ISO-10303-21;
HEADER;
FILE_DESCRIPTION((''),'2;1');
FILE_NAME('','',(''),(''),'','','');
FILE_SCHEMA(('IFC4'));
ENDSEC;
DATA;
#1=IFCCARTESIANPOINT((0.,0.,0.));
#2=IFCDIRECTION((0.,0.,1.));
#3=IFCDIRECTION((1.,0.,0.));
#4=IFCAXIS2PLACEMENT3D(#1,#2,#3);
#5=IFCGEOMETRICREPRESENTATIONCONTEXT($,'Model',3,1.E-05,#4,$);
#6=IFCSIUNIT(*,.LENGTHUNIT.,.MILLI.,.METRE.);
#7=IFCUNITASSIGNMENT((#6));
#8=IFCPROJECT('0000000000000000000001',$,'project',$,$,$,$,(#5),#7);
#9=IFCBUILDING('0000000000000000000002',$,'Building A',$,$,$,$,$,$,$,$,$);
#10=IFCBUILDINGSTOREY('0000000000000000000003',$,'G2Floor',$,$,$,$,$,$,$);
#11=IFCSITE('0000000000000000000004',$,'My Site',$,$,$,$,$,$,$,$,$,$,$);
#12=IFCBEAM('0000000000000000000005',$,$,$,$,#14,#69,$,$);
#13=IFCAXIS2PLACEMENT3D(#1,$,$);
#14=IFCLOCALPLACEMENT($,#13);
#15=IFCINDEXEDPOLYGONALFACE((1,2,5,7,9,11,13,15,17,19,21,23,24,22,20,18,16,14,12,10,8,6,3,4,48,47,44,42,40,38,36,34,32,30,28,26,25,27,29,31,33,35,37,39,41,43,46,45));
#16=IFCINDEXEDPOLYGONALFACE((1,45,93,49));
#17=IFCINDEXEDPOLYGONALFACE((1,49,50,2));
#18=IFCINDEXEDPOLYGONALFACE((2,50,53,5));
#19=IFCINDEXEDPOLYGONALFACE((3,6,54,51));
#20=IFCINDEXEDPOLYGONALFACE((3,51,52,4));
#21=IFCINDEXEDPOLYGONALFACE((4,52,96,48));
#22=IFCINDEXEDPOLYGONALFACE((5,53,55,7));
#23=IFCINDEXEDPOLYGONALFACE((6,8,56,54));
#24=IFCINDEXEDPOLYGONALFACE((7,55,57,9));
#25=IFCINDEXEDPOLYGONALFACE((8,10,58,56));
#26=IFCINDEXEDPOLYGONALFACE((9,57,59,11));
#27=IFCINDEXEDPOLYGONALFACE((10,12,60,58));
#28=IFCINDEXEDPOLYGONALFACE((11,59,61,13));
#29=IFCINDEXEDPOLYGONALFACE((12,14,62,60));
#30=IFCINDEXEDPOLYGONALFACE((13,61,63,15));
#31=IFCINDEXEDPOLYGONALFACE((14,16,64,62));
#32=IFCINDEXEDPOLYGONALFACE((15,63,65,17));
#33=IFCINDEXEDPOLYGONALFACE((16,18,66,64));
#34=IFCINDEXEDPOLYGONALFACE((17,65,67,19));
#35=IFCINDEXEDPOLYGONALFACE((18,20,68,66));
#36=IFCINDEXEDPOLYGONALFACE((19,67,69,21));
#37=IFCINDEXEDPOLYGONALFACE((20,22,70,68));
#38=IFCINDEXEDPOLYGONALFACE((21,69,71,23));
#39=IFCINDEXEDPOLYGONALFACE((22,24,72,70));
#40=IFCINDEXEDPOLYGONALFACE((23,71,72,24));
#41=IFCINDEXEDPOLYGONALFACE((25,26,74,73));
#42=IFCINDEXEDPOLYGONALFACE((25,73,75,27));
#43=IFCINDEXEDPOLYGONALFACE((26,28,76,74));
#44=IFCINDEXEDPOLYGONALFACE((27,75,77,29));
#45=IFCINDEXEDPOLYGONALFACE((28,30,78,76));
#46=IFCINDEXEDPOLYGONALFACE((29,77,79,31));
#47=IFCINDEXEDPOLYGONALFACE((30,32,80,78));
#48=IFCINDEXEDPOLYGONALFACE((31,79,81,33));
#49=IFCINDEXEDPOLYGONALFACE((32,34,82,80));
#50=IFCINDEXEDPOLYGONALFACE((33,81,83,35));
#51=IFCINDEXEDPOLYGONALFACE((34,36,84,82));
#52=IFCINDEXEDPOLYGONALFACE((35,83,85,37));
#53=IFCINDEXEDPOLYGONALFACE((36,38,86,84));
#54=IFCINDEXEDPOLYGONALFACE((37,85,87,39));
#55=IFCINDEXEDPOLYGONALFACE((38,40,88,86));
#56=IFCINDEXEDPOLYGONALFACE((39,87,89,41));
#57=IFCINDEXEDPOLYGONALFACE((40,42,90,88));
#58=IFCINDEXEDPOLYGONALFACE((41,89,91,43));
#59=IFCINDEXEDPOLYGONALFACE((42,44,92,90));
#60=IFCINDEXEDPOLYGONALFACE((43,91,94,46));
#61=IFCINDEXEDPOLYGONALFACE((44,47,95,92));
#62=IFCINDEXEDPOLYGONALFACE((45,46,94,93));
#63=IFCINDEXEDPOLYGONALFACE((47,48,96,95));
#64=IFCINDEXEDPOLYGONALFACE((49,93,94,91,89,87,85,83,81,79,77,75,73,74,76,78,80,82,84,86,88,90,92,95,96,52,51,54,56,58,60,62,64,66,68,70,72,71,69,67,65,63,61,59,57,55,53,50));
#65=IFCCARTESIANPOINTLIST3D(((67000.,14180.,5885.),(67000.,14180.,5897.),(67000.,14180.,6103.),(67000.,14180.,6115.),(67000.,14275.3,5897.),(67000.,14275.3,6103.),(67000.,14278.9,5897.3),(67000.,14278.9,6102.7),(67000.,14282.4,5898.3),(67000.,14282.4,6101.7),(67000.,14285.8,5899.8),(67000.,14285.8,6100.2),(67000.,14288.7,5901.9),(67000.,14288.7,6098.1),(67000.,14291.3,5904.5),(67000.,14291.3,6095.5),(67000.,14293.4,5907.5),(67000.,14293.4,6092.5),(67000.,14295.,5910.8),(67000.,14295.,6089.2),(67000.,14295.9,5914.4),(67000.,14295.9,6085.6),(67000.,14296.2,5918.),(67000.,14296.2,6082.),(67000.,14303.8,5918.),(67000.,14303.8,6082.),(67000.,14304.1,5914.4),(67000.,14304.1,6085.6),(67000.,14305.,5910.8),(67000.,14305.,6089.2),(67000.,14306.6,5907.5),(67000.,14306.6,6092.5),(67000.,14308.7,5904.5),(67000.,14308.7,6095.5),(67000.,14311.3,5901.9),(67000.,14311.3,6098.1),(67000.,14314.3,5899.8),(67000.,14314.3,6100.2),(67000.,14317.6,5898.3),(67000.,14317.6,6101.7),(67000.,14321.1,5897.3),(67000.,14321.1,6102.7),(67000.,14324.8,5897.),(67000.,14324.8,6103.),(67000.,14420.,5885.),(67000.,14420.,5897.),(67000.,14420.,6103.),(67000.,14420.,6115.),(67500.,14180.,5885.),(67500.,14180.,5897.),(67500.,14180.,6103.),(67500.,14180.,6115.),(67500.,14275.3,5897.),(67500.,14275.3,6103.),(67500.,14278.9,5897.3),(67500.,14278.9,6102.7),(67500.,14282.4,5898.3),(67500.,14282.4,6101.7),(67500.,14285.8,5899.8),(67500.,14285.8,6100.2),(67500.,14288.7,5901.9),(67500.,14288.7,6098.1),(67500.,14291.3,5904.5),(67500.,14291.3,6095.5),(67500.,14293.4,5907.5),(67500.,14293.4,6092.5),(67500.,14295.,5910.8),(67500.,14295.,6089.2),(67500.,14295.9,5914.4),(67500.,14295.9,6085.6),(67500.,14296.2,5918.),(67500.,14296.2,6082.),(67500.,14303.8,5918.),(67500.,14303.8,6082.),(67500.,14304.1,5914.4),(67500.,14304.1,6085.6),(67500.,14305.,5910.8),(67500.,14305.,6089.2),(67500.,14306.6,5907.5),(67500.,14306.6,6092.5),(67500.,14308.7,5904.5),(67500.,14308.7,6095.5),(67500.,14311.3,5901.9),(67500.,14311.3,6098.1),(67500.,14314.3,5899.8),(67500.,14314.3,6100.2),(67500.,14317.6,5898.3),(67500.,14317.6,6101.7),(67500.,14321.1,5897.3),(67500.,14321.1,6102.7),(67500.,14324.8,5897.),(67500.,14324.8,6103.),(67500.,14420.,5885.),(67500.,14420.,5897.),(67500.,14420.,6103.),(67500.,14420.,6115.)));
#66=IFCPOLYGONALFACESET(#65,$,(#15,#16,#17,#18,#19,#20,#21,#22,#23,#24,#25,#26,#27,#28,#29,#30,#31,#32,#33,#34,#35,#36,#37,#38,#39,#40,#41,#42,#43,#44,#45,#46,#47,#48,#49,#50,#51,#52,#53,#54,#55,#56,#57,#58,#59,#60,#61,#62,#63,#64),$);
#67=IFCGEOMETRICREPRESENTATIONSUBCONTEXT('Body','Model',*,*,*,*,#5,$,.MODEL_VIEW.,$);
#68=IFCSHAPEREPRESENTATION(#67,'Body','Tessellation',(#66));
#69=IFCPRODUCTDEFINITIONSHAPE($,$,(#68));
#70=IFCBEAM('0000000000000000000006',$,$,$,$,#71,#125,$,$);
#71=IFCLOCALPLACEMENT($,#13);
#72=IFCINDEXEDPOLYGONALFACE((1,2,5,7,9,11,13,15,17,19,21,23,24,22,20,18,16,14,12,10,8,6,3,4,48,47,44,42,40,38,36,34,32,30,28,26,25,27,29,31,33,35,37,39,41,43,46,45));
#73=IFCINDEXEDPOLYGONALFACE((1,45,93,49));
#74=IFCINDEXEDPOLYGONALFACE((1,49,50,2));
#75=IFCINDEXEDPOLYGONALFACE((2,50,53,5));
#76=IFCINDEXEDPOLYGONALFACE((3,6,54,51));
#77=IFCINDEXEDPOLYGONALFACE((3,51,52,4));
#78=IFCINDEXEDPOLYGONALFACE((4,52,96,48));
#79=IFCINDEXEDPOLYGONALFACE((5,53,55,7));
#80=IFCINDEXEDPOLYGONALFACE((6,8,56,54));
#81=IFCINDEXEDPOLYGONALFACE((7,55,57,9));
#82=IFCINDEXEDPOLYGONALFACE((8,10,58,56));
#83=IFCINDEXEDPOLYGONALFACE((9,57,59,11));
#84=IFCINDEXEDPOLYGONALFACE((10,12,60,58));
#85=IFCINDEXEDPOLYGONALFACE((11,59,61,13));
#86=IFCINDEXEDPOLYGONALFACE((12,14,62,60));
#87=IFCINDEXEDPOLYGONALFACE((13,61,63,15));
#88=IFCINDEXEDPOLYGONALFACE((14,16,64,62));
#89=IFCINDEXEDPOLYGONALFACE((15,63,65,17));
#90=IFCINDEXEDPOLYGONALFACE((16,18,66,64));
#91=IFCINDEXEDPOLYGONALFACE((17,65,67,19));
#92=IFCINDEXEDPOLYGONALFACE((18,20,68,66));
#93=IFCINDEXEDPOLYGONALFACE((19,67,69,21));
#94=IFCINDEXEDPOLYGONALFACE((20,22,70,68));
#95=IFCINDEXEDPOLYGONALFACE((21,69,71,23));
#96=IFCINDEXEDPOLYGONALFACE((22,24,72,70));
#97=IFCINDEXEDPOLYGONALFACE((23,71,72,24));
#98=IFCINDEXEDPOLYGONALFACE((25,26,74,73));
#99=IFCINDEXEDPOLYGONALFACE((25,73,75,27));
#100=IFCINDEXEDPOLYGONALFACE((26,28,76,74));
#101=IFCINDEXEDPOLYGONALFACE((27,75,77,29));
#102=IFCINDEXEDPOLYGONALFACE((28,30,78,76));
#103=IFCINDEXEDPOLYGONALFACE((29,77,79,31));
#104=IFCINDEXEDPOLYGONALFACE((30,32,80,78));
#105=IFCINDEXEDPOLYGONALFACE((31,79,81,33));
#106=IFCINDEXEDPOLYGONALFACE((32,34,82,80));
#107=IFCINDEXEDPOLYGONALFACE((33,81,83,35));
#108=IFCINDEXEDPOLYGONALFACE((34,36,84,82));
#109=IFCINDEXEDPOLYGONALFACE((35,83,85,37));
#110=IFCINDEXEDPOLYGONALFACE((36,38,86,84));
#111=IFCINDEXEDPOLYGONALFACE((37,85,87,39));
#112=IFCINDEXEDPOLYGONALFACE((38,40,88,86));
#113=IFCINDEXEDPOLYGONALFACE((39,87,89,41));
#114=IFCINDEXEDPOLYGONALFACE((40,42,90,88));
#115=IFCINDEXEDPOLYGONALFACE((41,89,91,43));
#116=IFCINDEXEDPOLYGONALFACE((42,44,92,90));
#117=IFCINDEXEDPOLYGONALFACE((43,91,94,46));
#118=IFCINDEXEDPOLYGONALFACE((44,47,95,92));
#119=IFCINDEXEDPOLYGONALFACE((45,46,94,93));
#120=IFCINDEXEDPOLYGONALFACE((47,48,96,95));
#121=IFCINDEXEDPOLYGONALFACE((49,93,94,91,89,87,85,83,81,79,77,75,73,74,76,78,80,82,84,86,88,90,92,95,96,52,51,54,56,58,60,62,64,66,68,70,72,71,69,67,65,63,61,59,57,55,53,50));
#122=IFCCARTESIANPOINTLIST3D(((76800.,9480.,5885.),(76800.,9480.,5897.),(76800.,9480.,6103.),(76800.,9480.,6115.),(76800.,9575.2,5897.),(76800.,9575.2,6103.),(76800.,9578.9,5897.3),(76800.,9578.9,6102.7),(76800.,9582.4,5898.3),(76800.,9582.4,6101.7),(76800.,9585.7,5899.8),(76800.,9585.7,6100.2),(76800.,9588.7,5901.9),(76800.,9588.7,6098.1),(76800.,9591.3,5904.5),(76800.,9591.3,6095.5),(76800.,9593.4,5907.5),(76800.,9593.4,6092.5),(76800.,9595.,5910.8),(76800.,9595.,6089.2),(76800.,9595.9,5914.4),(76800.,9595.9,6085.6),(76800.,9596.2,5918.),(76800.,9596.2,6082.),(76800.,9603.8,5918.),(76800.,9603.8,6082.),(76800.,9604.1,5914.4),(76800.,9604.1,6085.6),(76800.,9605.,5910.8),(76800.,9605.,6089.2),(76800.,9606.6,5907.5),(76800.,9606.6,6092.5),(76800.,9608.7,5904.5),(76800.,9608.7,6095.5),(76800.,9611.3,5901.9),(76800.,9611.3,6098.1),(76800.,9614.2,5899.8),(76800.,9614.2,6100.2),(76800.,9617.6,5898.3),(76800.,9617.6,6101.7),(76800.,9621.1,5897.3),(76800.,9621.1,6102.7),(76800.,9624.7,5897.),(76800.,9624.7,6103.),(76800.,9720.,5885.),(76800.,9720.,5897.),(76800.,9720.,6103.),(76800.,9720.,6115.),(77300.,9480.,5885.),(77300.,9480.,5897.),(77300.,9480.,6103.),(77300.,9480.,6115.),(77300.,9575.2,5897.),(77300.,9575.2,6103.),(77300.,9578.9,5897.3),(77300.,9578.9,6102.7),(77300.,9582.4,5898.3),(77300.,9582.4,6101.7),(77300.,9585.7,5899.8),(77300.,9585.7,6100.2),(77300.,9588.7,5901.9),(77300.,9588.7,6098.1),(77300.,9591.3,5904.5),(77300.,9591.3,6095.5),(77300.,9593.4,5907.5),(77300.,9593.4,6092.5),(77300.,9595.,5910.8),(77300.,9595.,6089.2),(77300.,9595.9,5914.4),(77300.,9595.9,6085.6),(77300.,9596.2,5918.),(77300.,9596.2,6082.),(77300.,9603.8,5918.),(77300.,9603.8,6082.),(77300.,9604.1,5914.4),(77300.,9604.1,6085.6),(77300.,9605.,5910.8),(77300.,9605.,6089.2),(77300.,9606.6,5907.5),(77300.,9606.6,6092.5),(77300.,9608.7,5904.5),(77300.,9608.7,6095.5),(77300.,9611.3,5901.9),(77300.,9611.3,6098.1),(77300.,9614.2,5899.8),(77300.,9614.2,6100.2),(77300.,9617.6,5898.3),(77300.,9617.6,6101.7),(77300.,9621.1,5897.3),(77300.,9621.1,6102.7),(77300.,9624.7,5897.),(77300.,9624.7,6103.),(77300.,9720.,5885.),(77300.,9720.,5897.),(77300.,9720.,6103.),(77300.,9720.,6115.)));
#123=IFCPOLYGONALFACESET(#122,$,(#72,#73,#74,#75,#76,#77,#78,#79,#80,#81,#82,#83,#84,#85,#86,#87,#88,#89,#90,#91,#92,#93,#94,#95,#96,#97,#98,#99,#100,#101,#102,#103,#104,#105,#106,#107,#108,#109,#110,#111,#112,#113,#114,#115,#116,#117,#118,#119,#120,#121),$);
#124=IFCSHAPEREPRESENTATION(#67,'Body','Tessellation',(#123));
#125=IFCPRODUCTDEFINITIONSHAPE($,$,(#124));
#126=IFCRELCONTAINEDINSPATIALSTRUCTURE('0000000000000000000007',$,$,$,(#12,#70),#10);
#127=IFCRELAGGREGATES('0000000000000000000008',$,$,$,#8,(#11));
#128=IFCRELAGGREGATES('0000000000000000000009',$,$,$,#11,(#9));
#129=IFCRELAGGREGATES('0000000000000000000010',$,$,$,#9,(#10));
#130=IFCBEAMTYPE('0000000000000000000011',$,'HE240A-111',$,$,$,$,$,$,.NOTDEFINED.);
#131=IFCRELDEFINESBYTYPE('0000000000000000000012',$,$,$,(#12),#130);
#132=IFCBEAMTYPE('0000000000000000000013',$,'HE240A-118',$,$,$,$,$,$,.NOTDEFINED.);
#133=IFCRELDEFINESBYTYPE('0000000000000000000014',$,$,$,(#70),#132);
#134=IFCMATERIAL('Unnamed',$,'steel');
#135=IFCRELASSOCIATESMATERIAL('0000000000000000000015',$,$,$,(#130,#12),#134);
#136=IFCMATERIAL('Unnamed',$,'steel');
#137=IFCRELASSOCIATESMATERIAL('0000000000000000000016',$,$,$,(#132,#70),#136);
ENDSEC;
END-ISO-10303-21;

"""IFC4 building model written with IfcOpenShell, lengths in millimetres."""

from ifc_helpers import new_model, si_unit, frame, origin_with_axes, place, context, subcontext, project, spatial, polyline, outline, extrude, material, material_profile, profile_set, profile_usage, type_object, element, save


model = new_model("IFC4")

# Units and contexts
model_context = context("Model", 3, precision=1e-05, world=origin_with_axes())
body_context = subcontext(model_context, "Body", "Model", "MODEL_VIEW")
ifc_project = project(units=[si_unit("LENGTHUNIT", "METRE", prefix="MILLI")], contexts=[model_context])

# Site, building, storey
site = spatial("IfcSite", under=ifc_project, Name="My Site")
building = spatial("IfcBuilding", under=site, Name="Building A")
storey = spatial("IfcBuildingStorey", under=building, Name="G2Floor")

# Beams
ifc_material_1 = material(Name="Unnamed", Category="steel")
ifc_material_profile_1 = material_profile(ifc_material_1, outline(polyline([(120.0, -115.0), (120.0, -103.0), (120.0, -103.0), (24.8, -103.0), (24.8, -103.0), (21.1, -102.7), (21.1, -102.7), (17.6, -101.7), (17.6, -101.7), (14.2, -100.2), (14.2, -100.2), (11.3, -98.1), (11.3, -98.1), (8.7, -95.5), (8.7, -95.5), (6.6, -92.5), (6.6, -92.5), (5.0, -89.2), (5.0, -89.2), (4.1, -85.6), (4.1, -85.6), (3.8, -82.0), (3.8, -82.0), (3.8, 82.0), (3.8, 82.0), (4.1, 85.6), (4.1, 85.6), (5.0, 89.2), (5.0, 89.2), (6.6, 92.5), (6.6, 92.5), (8.7, 95.5), (8.7, 95.5), (11.3, 98.1), (11.3, 98.1), (14.2, 100.2), (14.2, 100.2), (17.6, 101.7), (17.6, 101.7), (21.1, 102.7), (21.1, 102.7), (24.8, 103.0), (24.8, 103.0), (120.0, 103.0), (120.0, 103.0), (120.0, 115.0), (120.0, 115.0), (-120.0, 115.0), (-120.0, 115.0), (-120.0, 103.0), (-120.0, 103.0), (-24.8, 103.0), (-24.8, 103.0), (-21.1, 102.7), (-21.1, 102.7), (-17.6, 101.7), (-17.6, 101.7), (-14.2, 100.2), (-14.2, 100.2), (-11.3, 98.1), (-11.3, 98.1), (-8.7, 95.5), (-8.7, 95.5), (-6.6, 92.5), (-6.6, 92.5), (-5.0, 89.2), (-5.0, 89.2), (-4.1, 85.6), (-4.1, 85.6), (-3.8, 82.0), (-3.8, 82.0), (-3.8, -82.0), (-3.8, -82.0), (-4.1, -85.6), (-4.1, -85.6), (-5.0, -89.2), (-5.0, -89.2), (-6.6, -92.5), (-6.6, -92.5), (-8.7, -95.5), (-8.7, -95.5), (-11.3, -98.1), (-11.3, -98.1), (-14.2, -100.2), (-14.2, -100.2), (-17.6, -101.7), (-17.6, -101.7), (-21.1, -102.7), (-21.1, -102.7), (-24.8, -103.0), (-24.8, -103.0), (-120.0, -103.0), (-120.0, -103.0), (-120.0, -115.0), (-120.0, -115.0), (120.0, -115.0)])))
ifc_profile_set_1 = profile_set([ifc_material_profile_1], Name="HE240A-111")
ifc_profile_usage_1 = profile_usage(ifc_profile_set_1)
beam_type_1 = type_object("IfcBeamType", Name="HE240A-111", PredefinedType="NOTDEFINED", material=ifc_profile_set_1)
beam_1_placement = place(None, frame((67000.0, 14300.0, 6000.0), z_axis=(1.0, 0.0, 0.0), x_axis=(0.0, -1.0, 0.0)))
element("IfcBeam", 1, at=beam_1_placement, inside=storey, type_object=beam_type_1, material=ifc_profile_usage_1, context=body_context, shape_type="SweptSolid", body=[
    extrude(outline(polyline([(120.0, -115.0), (120.0, -103.0), (120.0, -103.0), (24.8, -103.0), (24.8, -103.0), (21.1, -102.7), (21.1, -102.7), (17.6, -101.7), (17.6, -101.7), (14.2, -100.2), (14.2, -100.2), (11.3, -98.1), (11.3, -98.1), (8.7, -95.5), (8.7, -95.5), (6.6, -92.5), (6.6, -92.5), (5.0, -89.2), (5.0, -89.2), (4.1, -85.6), (4.1, -85.6), (3.8, -82.0), (3.8, -82.0), (3.8, 82.0), (3.8, 82.0), (4.1, 85.6), (4.1, 85.6), (5.0, 89.2), (5.0, 89.2), (6.6, 92.5), (6.6, 92.5), (8.7, 95.5), (8.7, 95.5), (11.3, 98.1), (11.3, 98.1), (14.2, 100.2), (14.2, 100.2), (17.6, 101.7), (17.6, 101.7), (21.1, 102.7), (21.1, 102.7), (24.8, 103.0), (24.8, 103.0), (120.0, 103.0), (120.0, 103.0), (120.0, 115.0), (120.0, 115.0), (-120.0, 115.0), (-120.0, 115.0), (-120.0, 103.0), (-120.0, 103.0), (-24.8, 103.0), (-24.8, 103.0), (-21.1, 102.7), (-21.1, 102.7), (-17.6, 101.7), (-17.6, 101.7), (-14.2, 100.2), (-14.2, 100.2), (-11.3, 98.1), (-11.3, 98.1), (-8.7, 95.5), (-8.7, 95.5), (-6.6, 92.5), (-6.6, 92.5), (-5.0, 89.2), (-5.0, 89.2), (-4.1, 85.6), (-4.1, 85.6), (-3.8, 82.0), (-3.8, 82.0), (-3.8, -82.0), (-3.8, -82.0), (-4.1, -85.6), (-4.1, -85.6), (-5.0, -89.2), (-5.0, -89.2), (-6.6, -92.5), (-6.6, -92.5), (-8.7, -95.5), (-8.7, -95.5), (-11.3, -98.1), (-11.3, -98.1), (-14.2, -100.2), (-14.2, -100.2), (-17.6, -101.7), (-17.6, -101.7), (-21.1, -102.7), (-21.1, -102.7), (-24.8, -103.0), (-24.8, -103.0), (-120.0, -103.0), (-120.0, -103.0), (-120.0, -115.0), (-120.0, -115.0), (120.0, -115.0)])), origin_with_axes(), (0.0, 0.0, 1.0), 500.0),
])
ifc_material_2 = material(Name="Unnamed", Category="steel")
ifc_material_profile_2 = material_profile(ifc_material_2, outline(polyline([(120.0, -115.0), (120.0, -103.0), (120.0, -103.0), (24.8, -103.0), (24.8, -103.0), (21.1, -102.7), (21.1, -102.7), (17.6, -101.7), (17.6, -101.7), (14.2, -100.2), (14.2, -100.2), (11.3, -98.1), (11.3, -98.1), (8.7, -95.5), (8.7, -95.5), (6.6, -92.5), (6.6, -92.5), (5.0, -89.2), (5.0, -89.2), (4.1, -85.6), (4.1, -85.6), (3.8, -82.0), (3.8, -82.0), (3.8, 82.0), (3.8, 82.0), (4.1, 85.6), (4.1, 85.6), (5.0, 89.2), (5.0, 89.2), (6.6, 92.5), (6.6, 92.5), (8.7, 95.5), (8.7, 95.5), (11.3, 98.1), (11.3, 98.1), (14.2, 100.2), (14.2, 100.2), (17.6, 101.7), (17.6, 101.7), (21.1, 102.7), (21.1, 102.7), (24.8, 103.0), (24.8, 103.0), (120.0, 103.0), (120.0, 103.0), (120.0, 115.0), (120.0, 115.0), (-120.0, 115.0), (-120.0, 115.0), (-120.0, 103.0), (-120.0, 103.0), (-24.8, 103.0), (-24.8, 103.0), (-21.1, 102.7), (-21.1, 102.7), (-17.6, 101.7), (-17.6, 101.7), (-14.2, 100.2), (-14.2, 100.2), (-11.3, 98.1), (-11.3, 98.1), (-8.7, 95.5), (-8.7, 95.5), (-6.6, 92.5), (-6.6, 92.5), (-5.0, 89.2), (-5.0, 89.2), (-4.1, 85.6), (-4.1, 85.6), (-3.8, 82.0), (-3.8, 82.0), (-3.8, -82.0), (-3.8, -82.0), (-4.1, -85.6), (-4.1, -85.6), (-5.0, -89.2), (-5.0, -89.2), (-6.6, -92.5), (-6.6, -92.5), (-8.7, -95.5), (-8.7, -95.5), (-11.3, -98.1), (-11.3, -98.1), (-14.2, -100.2), (-14.2, -100.2), (-17.6, -101.7), (-17.6, -101.7), (-21.1, -102.7), (-21.1, -102.7), (-24.8, -103.0), (-24.8, -103.0), (-120.0, -103.0), (-120.0, -103.0), (-120.0, -115.0), (-120.0, -115.0), (120.0, -115.0)])))
ifc_profile_set_2 = profile_set([ifc_material_profile_2], Name="HE240A-118")
ifc_profile_usage_2 = profile_usage(ifc_profile_set_2)
beam_type_2 = type_object("IfcBeamType", Name="HE240A-118", PredefinedType="NOTDEFINED", material=ifc_profile_set_2)
beam_2_placement = place(None, frame((76800.0, 9600.0, 6000.0), z_axis=(1.0, 0.0, 0.0), x_axis=(0.0, -1.0, 0.0)))
element("IfcBeam", 2, at=beam_2_placement, inside=storey, type_object=beam_type_2, material=ifc_profile_usage_2, context=body_context, shape_type="SweptSolid", body=[
    extrude(outline(polyline([(120.0, -115.0), (120.0, -103.0), (120.0, -103.0), (24.8, -103.0), (24.8, -103.0), (21.1, -102.7), (21.1, -102.7), (17.6, -101.7), (17.6, -101.7), (14.2, -100.2), (14.2, -100.2), (11.3, -98.1), (11.3, -98.1), (8.7, -95.5), (8.7, -95.5), (6.6, -92.5), (6.6, -92.5), (5.0, -89.2), (5.0, -89.2), (4.1, -85.6), (4.1, -85.6), (3.8, -82.0), (3.8, -82.0), (3.8, 82.0), (3.8, 82.0), (4.1, 85.6), (4.1, 85.6), (5.0, 89.2), (5.0, 89.2), (6.6, 92.5), (6.6, 92.5), (8.7, 95.5), (8.7, 95.5), (11.3, 98.1), (11.3, 98.1), (14.2, 100.2), (14.2, 100.2), (17.6, 101.7), (17.6, 101.7), (21.1, 102.7), (21.1, 102.7), (24.8, 103.0), (24.8, 103.0), (120.0, 103.0), (120.0, 103.0), (120.0, 115.0), (120.0, 115.0), (-120.0, 115.0), (-120.0, 115.0), (-120.0, 103.0), (-120.0, 103.0), (-24.8, 103.0), (-24.8, 103.0), (-21.1, 102.7), (-21.1, 102.7), (-17.6, 101.7), (-17.6, 101.7), (-14.2, 100.2), (-14.2, 100.2), (-11.3, 98.1), (-11.3, 98.1), (-8.7, 95.5), (-8.7, 95.5), (-6.6, 92.5), (-6.6, 92.5), (-5.0, 89.2), (-5.0, 89.2), (-4.1, 85.6), (-4.1, 85.6), (-3.8, 82.0), (-3.8, 82.0), (-3.8, -82.0), (-3.8, -82.0), (-4.1, -85.6), (-4.1, -85.6), (-5.0, -89.2), (-5.0, -89.2), (-6.6, -92.5), (-6.6, -92.5), (-8.7, -95.5), (-8.7, -95.5), (-11.3, -98.1), (-11.3, -98.1), (-14.2, -100.2), (-14.2, -100.2), (-17.6, -101.7), (-17.6, -101.7), (-21.1, -102.7), (-21.1, -102.7), (-24.8, -103.0), (-24.8, -103.0), (-120.0, -103.0), (-120.0, -103.0), (-120.0, -115.0), (-120.0, -115.0), (120.0, -115.0)])), origin_with_axes(), (0.0, 0.0, 1.0), 500.0),
])

save(model, "model.ifc")
